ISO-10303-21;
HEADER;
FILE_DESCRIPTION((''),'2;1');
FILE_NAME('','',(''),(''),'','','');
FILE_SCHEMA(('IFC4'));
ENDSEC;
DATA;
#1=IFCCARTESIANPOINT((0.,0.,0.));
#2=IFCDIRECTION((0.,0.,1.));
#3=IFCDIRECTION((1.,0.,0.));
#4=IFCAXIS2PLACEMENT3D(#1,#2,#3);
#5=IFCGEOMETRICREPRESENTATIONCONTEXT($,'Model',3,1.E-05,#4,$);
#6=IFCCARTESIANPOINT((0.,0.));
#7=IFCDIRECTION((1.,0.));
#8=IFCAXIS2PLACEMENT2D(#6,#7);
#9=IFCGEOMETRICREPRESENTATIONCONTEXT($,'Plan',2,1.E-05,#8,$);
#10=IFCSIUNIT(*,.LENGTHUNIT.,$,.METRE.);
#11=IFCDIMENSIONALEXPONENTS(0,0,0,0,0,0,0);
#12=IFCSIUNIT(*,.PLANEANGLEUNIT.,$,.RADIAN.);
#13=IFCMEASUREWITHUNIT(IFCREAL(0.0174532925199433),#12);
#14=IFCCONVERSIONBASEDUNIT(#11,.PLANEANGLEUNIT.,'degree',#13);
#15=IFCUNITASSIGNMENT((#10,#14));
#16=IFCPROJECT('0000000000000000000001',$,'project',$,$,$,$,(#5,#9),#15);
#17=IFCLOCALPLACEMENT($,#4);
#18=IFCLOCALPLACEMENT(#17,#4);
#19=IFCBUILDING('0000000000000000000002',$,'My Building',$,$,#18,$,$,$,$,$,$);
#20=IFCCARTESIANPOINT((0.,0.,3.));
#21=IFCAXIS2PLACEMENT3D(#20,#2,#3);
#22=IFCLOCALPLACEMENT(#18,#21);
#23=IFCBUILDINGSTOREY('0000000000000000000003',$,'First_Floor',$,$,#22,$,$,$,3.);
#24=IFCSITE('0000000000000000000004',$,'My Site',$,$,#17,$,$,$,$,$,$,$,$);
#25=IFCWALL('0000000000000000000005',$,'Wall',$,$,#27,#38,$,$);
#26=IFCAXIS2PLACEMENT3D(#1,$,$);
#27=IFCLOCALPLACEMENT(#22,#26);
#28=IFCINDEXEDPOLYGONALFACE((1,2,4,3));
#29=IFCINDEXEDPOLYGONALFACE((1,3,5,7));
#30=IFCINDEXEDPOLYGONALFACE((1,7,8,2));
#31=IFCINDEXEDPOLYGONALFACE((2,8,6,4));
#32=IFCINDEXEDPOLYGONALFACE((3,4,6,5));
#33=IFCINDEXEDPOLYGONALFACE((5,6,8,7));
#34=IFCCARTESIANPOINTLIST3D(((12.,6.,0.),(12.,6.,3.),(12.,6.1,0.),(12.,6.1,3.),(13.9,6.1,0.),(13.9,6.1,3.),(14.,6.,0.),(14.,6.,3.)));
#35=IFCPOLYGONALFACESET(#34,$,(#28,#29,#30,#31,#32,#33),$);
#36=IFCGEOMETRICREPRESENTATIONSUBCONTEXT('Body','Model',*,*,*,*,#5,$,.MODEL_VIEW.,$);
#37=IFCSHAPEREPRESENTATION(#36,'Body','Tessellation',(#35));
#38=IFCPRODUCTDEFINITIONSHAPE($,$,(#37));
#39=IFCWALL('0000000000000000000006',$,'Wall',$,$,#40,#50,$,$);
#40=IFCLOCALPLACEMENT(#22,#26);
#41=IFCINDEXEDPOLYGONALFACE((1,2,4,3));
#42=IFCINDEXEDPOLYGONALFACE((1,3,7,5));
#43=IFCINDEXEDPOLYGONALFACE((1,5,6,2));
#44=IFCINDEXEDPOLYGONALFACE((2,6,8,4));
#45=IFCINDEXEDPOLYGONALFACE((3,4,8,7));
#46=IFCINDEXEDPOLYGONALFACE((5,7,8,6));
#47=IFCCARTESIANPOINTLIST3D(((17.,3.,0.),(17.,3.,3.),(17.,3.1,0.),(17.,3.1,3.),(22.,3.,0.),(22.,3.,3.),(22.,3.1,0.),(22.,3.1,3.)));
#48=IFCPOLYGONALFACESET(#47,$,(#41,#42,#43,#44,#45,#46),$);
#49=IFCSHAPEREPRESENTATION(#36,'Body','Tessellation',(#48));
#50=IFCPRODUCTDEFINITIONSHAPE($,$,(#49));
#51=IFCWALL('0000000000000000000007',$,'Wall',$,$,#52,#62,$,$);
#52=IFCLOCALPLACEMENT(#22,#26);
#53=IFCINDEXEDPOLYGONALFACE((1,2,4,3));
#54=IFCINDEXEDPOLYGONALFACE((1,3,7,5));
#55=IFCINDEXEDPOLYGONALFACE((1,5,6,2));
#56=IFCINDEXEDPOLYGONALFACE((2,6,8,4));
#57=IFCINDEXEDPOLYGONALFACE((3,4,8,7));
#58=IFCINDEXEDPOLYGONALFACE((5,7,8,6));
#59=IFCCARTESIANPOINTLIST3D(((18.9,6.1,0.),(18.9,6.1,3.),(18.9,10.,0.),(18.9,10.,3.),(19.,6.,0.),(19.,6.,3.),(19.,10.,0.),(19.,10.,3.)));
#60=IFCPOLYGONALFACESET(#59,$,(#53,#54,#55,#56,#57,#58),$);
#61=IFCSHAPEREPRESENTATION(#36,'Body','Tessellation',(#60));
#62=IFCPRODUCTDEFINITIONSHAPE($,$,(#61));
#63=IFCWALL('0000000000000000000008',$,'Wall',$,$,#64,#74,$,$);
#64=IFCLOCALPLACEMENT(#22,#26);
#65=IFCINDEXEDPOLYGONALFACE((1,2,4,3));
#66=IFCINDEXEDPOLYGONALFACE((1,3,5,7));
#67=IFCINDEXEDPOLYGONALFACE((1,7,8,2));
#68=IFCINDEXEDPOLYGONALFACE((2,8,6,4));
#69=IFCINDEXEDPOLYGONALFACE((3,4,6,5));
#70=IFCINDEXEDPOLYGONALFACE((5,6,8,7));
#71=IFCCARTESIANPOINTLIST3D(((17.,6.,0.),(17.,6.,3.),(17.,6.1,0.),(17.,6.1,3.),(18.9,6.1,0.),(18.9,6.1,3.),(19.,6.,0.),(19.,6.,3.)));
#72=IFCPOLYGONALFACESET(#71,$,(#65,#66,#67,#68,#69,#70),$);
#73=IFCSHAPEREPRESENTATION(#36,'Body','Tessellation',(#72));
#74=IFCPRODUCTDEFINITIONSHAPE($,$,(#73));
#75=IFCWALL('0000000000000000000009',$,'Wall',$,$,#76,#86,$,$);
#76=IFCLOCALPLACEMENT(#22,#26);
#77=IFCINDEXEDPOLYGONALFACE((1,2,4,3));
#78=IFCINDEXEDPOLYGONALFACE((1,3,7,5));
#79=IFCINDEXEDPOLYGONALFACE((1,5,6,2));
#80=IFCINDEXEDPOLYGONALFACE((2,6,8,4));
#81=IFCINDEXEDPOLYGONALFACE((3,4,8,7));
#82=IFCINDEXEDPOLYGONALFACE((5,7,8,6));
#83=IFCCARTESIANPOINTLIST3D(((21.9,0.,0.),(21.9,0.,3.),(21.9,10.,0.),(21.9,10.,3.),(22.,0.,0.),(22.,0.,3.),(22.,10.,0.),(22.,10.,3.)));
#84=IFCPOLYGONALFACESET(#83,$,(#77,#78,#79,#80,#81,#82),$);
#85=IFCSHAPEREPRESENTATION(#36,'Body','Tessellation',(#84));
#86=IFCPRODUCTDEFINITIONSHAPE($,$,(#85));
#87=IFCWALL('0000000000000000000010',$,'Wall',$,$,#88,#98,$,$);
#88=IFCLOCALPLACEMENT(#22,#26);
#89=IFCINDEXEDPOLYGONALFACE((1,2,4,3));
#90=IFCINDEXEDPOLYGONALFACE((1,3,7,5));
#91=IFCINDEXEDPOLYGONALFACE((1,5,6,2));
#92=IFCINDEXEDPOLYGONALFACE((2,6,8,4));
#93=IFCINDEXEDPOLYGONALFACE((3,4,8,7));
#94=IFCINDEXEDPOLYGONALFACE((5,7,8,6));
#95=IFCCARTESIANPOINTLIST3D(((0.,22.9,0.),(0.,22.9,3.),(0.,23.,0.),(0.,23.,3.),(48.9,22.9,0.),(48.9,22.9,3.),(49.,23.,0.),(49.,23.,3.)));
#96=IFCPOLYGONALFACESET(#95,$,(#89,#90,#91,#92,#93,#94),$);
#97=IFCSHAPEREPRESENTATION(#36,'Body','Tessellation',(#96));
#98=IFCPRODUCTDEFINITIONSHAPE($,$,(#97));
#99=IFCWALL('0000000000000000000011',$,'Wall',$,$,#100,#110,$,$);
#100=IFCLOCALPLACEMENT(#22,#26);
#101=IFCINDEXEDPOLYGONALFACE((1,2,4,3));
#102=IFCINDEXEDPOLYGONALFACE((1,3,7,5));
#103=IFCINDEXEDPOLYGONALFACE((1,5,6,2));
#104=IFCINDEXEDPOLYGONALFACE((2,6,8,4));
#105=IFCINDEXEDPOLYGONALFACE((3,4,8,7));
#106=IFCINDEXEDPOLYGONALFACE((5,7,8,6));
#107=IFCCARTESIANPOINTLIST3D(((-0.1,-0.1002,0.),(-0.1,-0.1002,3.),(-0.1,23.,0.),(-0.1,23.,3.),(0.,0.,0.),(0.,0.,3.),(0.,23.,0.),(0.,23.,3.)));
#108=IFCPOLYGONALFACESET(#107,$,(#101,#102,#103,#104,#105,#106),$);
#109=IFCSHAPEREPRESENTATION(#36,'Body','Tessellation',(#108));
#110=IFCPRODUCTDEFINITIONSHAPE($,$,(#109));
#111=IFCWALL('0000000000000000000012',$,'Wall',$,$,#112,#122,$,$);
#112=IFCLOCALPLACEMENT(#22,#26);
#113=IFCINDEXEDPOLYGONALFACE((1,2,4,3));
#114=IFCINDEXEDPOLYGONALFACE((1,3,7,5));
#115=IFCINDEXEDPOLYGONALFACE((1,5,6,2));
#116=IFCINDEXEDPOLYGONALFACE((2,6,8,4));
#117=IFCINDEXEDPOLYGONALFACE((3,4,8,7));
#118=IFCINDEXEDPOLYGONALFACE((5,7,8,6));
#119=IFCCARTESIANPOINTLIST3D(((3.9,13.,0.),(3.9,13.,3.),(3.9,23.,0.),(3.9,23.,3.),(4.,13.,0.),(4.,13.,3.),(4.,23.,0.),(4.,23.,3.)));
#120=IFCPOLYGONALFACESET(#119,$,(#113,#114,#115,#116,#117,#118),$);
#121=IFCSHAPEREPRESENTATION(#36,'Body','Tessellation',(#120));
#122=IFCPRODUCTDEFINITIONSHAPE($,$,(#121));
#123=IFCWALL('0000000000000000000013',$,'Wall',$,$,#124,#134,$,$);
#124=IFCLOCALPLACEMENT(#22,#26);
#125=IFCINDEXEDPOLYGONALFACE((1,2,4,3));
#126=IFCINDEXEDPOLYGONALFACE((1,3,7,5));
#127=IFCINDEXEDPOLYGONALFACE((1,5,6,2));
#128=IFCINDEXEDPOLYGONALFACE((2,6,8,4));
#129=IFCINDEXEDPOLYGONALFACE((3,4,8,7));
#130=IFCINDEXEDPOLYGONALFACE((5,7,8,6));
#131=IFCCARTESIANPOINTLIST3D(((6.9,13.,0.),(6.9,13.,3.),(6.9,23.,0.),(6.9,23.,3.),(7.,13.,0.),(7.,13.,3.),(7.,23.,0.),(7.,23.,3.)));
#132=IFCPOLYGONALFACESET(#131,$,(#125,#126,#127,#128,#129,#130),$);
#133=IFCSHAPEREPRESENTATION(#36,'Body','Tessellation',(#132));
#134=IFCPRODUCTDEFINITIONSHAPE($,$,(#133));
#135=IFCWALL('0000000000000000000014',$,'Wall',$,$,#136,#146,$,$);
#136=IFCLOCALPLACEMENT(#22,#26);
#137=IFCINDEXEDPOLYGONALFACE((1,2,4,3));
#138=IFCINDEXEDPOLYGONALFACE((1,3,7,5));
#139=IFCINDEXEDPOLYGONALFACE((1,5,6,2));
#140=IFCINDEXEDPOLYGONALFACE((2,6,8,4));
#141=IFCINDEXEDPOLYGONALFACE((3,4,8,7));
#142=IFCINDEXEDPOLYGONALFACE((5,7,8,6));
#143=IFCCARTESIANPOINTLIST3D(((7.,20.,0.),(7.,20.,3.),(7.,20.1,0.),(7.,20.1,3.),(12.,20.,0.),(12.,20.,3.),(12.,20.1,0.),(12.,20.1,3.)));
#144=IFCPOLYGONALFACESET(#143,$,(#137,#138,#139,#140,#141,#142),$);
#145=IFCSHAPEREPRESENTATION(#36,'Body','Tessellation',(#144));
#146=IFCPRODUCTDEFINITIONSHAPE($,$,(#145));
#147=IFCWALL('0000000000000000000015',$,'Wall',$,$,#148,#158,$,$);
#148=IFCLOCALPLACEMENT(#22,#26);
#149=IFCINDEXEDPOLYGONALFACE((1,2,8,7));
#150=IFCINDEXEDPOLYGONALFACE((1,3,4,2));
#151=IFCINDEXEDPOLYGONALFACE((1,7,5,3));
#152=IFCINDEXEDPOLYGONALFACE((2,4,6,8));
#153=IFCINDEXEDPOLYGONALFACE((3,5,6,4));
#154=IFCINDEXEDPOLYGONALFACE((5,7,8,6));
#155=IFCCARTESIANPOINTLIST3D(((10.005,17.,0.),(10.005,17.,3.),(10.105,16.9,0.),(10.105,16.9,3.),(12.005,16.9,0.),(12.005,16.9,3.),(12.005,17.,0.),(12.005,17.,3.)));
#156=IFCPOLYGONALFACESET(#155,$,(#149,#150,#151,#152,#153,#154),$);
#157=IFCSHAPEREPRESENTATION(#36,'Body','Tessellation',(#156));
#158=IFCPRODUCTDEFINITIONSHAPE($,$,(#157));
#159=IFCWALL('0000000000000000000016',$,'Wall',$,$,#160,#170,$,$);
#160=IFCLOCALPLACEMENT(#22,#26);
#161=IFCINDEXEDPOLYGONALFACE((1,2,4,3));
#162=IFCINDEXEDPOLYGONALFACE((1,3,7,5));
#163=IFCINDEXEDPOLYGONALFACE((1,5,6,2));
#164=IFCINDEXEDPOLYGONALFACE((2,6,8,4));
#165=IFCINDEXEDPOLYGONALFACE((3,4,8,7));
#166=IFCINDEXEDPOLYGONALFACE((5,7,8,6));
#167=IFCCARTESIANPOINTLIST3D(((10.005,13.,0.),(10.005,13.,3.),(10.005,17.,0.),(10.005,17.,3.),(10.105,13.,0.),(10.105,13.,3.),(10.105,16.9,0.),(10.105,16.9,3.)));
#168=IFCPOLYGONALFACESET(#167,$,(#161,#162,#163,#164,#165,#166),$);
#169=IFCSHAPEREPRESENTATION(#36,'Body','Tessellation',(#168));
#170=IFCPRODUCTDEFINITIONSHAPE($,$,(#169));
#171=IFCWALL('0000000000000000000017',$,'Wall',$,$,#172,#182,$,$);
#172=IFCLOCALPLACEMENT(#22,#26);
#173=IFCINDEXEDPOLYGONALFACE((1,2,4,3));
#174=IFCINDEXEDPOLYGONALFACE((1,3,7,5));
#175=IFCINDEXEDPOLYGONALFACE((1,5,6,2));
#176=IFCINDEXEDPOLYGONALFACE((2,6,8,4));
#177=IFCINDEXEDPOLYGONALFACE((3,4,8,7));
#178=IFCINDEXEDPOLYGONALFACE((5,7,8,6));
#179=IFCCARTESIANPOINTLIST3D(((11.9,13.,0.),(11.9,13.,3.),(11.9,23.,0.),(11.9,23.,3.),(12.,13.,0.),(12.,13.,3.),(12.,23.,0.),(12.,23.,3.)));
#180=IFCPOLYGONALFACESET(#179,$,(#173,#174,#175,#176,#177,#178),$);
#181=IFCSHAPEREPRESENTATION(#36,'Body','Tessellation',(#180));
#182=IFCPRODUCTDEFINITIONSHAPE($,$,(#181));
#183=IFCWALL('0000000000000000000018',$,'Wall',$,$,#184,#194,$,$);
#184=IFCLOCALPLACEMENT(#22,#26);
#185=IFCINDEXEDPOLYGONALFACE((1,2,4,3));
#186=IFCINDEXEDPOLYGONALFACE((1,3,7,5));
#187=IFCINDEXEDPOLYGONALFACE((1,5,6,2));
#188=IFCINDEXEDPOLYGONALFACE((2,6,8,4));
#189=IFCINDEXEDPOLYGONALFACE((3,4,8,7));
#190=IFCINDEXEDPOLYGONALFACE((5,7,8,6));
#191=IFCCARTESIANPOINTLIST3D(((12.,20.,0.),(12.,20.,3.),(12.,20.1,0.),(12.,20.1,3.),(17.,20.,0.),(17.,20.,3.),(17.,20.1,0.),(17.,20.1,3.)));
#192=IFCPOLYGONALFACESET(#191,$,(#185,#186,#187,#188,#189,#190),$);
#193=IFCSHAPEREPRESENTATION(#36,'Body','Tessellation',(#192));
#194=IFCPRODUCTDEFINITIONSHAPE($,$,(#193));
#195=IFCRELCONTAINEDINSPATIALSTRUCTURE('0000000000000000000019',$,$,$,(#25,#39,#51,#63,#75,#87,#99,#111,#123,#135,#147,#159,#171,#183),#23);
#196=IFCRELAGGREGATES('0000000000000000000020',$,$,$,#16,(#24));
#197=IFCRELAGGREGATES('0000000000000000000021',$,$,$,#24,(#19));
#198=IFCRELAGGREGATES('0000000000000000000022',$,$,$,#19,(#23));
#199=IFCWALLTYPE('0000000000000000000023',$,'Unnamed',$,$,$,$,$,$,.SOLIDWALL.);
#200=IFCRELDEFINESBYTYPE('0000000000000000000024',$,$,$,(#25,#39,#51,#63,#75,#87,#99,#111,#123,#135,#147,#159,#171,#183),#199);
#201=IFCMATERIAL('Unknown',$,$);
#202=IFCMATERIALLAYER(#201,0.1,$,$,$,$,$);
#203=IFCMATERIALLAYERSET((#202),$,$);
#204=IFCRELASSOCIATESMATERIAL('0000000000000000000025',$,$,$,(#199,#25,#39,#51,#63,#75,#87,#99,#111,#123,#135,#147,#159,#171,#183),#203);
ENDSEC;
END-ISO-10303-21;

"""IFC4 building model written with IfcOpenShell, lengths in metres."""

from ifc_helpers import new_model, entity, si_unit, converted_unit, frame, origin_with_axes, origin_2d_with_axis, place, context, subcontext, project, spatial, line, indexed_curve, outline, extrude, material, layer, layer_set, layer_usage, type_object, element, save


model = new_model("IFC4")

# Units and contexts
model_context = context("Model", 3, precision=1e-05, world=origin_with_axes())
plan_context = context("Plan", 2, precision=1e-05, world=origin_2d_with_axis())
body_context = subcontext(model_context, "Body", "Model", "MODEL_VIEW")
ifc_project = project(units=[si_unit("LENGTHUNIT", "METRE"), converted_unit("PLANEANGLEUNIT", "degree", entity("IfcReal", 0.0174532925199433), si_unit("PLANEANGLEUNIT", "RADIAN"), dimensions=[0, 0, 0, 0, 0, 0, 0])], contexts=[model_context, plan_context])

# Site, building, storey
site_placement = place(None, origin_with_axes())
site = spatial("IfcSite", under=ifc_project, at=site_placement, Name="My Site")
building_placement = place(site_placement, origin_with_axes())
building = spatial("IfcBuilding", under=site, at=building_placement, Name="My Building")
storey_placement = place(building_placement, frame((0.0, 0.0, 3.0), z_axis=(0.0, 0.0, 1.0), x_axis=(1.0, 0.0, 0.0)))
storey = spatial("IfcBuildingStorey", under=building, at=storey_placement, Name="First_Floor", Elevation=3.0)

# Shared definitions
ifc_material = material(Name="Unknown")

# Walls
ifc_layer = layer(ifc_material, 0.1)
ifc_layer_set = layer_set([ifc_layer])
wall_type = type_object("IfcWallType", Name="Unnamed", PredefinedType="SOLIDWALL", material=ifc_layer_set)
ifc_layer_usage_1 = layer_usage(ifc_layer_set, "AXIS2", "POSITIVE", 0.0)
wall_1_placement = place(storey_placement, frame((12.0, 6.0, 0.0), z_axis=(0.0, 0.0, 1.0), x_axis=(1.0, 0.0, 0.0)))
element("IfcWall", 1, at=wall_1_placement, inside=storey, type_object=wall_type, material=ifc_layer_usage_1, Name="Wall", context=body_context, shape_type="SweptSolid", body=[
    extrude(outline(indexed_curve([(0.0, 0.0), (0.0, 0.1), (1.9, 0.1), (2.0, 0.0)], segments=[line(1, 2, 3, 4, 1)])), origin_with_axes(), (0.0, 0.0, 1.0), 3.0),
])
ifc_layer_usage_2 = layer_usage(ifc_layer_set, "AXIS2", "POSITIVE", 0.0)
wall_2_placement = place(storey_placement, frame((17.0, 3.0, 0.0), z_axis=(0.0, 0.0, 1.0), x_axis=(1.0, 0.0, 0.0)))
element("IfcWall", 2, at=wall_2_placement, inside=storey, type_object=wall_type, material=ifc_layer_usage_2, Name="Wall", context=body_context, shape_type="SweptSolid", body=[
    extrude(outline(indexed_curve([(0.0, 0.0), (0.0, 0.1), (5.0, 0.1), (5.0, 0.0)], segments=[line(1, 2, 3, 4, 1)])), origin_with_axes(), (0.0, 0.0, 1.0), 3.0),
])
ifc_layer_usage_3 = layer_usage(ifc_layer_set, "AXIS2", "POSITIVE", 0.0)
wall_3_placement = place(storey_placement, frame((19.0, 6.0, 0.0), z_axis=(0.0, 0.0, 1.0), x_axis=(0.0, 1.0, 0.0)))
element("IfcWall", 3, at=wall_3_placement, inside=storey, type_object=wall_type, material=ifc_layer_usage_3, Name="Wall", context=body_context, shape_type="SweptSolid", body=[
    extrude(outline(indexed_curve([(0.0, 0.0), (0.1, 0.1), (4.0, 0.1), (4.0, 0.0)], segments=[line(1, 2, 3, 4, 1)])), origin_with_axes(), (0.0, 0.0, 1.0), 3.0),
])
ifc_layer_usage_4 = layer_usage(ifc_layer_set, "AXIS2", "POSITIVE", 0.0)
wall_4_placement = place(storey_placement, frame((17.0, 6.0, 0.0), z_axis=(0.0, 0.0, 1.0), x_axis=(1.0, 0.0, 0.0)))
element("IfcWall", 4, at=wall_4_placement, inside=storey, type_object=wall_type, material=ifc_layer_usage_4, Name="Wall", context=body_context, shape_type="SweptSolid", body=[
    extrude(outline(indexed_curve([(0.0, 0.0), (0.0, 0.1), (1.9, 0.1), (2.0, 0.0)], segments=[line(1, 2, 3, 4, 1)])), origin_with_axes(), (0.0, 0.0, 1.0), 3.0),
])
ifc_layer_usage_5 = layer_usage(ifc_layer_set, "AXIS2", "POSITIVE", 0.0)
wall_5_placement = place(storey_placement, frame((21.9, 10.0, 0.0), z_axis=(0.0, 0.0, 1.0), x_axis=(0.0, -1.0, 0.0)))
element("IfcWall", 5, at=wall_5_placement, inside=storey, type_object=wall_type, material=ifc_layer_usage_5, Name="Wall", context=body_context, shape_type="SweptSolid", body=[
    extrude(outline(indexed_curve([(0.0, 0.0), (0.0, 0.1), (10.0, 0.1), (10.0, 0.0)], segments=[line(1, 2, 3, 4, 1)])), origin_with_axes(), (0.0, 0.0, 1.0), 3.0),
])
ifc_layer_usage_6 = layer_usage(ifc_layer_set, "AXIS2", "POSITIVE", 0.0)
wall_6_placement = place(storey_placement, frame((0.0, 22.9, 0.0), z_axis=(0.0, 0.0, 1.0), x_axis=(1.0, 0.0, 0.0)))
element("IfcWall", 6, at=wall_6_placement, inside=storey, type_object=wall_type, material=ifc_layer_usage_6, Name="Wall", context=body_context, shape_type="SweptSolid", body=[
    extrude(outline(indexed_curve([(0.0, 0.0), (0.0, 0.1), (49.0, 0.1), (48.9, 0.0)], segments=[line(1, 2, 3, 4, 1)])), origin_with_axes(), (0.0, 0.0, 1.0), 3.0),
])
ifc_layer_usage_7 = layer_usage(ifc_layer_set, "AXIS2", "POSITIVE", 0.0)
wall_7_placement = place(storey_placement, frame((0.0, 0.0, 0.0), z_axis=(0.0, 0.0, 1.0), x_axis=(0.0, 1.0, 0.0)))
element("IfcWall", 7, at=wall_7_placement, inside=storey, type_object=wall_type, material=ifc_layer_usage_7, Name="Wall", context=body_context, shape_type="SweptSolid", body=[
    extrude(outline(indexed_curve([(0.0, 0.0), (-0.1002, 0.1), (23.0, 0.1), (23.0, 0.0)], segments=[line(1, 2, 3, 4, 1)])), origin_with_axes(), (0.0, 0.0, 1.0), 3.0),
])
ifc_layer_usage_8 = layer_usage(ifc_layer_set, "AXIS2", "POSITIVE", 0.0)
wall_8_placement = place(storey_placement, frame((3.9, 23.0, 0.0), z_axis=(0.0, 0.0, 1.0), x_axis=(0.0, -1.0, 0.0)))
element("IfcWall", 8, at=wall_8_placement, inside=storey, type_object=wall_type, material=ifc_layer_usage_8, Name="Wall", context=body_context, shape_type="SweptSolid", body=[
    extrude(outline(indexed_curve([(0.0, 0.0), (0.0, 0.1), (10.0, 0.1), (10.0, 0.0)], segments=[line(1, 2, 3, 4, 1)])), origin_with_axes(), (0.0, 0.0, 1.0), 3.0),
])
ifc_layer_usage_9 = layer_usage(ifc_layer_set, "AXIS2", "POSITIVE", 0.0)
wall_9_placement = place(storey_placement, frame((6.9, 23.0, 0.0), z_axis=(0.0, 0.0, 1.0), x_axis=(0.0, -1.0, 0.0)))
element("IfcWall", 9, at=wall_9_placement, inside=storey, type_object=wall_type, material=ifc_layer_usage_9, Name="Wall", context=body_context, shape_type="SweptSolid", body=[
    extrude(outline(indexed_curve([(0.0, 0.0), (0.0, 0.1), (10.0, 0.1), (10.0, 0.0)], segments=[line(1, 2, 3, 4, 1)])), origin_with_axes(), (0.0, 0.0, 1.0), 3.0),
])
ifc_layer_usage_10 = layer_usage(ifc_layer_set, "AXIS2", "POSITIVE", 0.0)
wall_10_placement = place(storey_placement, frame((7.0, 20.0, 0.0), z_axis=(0.0, 0.0, 1.0), x_axis=(1.0, 0.0, 0.0)))
element("IfcWall", 10, at=wall_10_placement, inside=storey, type_object=wall_type, material=ifc_layer_usage_10, Name="Wall", context=body_context, shape_type="SweptSolid", body=[
    extrude(outline(indexed_curve([(0.0, 0.0), (0.0, 0.1), (5.0, 0.1), (5.0, 0.0)], segments=[line(1, 2, 3, 4, 1)])), origin_with_axes(), (0.0, 0.0, 1.0), 3.0),
])
ifc_layer_usage_11 = layer_usage(ifc_layer_set, "AXIS2", "POSITIVE", 0.0)
wall_11_placement = place(storey_placement, frame((12.005, 17.0, 0.0), z_axis=(0.0, 0.0, 1.0), x_axis=(-1.0, 0.0, 0.0)))
element("IfcWall", 11, at=wall_11_placement, inside=storey, type_object=wall_type, material=ifc_layer_usage_11, Name="Wall", context=body_context, shape_type="SweptSolid", body=[
    extrude(outline(indexed_curve([(0.0, 0.0), (0.0, 0.1), (1.9, 0.1), (2.0, 0.0)], segments=[line(1, 2, 3, 4, 1)])), origin_with_axes(), (0.0, 0.0, 1.0), 3.0),
])
ifc_layer_usage_12 = layer_usage(ifc_layer_set, "AXIS2", "POSITIVE", 0.0)
wall_12_placement = place(storey_placement, frame((10.005, 17.0, 0.0), z_axis=(0.0, 0.0, 1.0), x_axis=(0.0, -1.0, 0.0)))
element("IfcWall", 12, at=wall_12_placement, inside=storey, type_object=wall_type, material=ifc_layer_usage_12, Name="Wall", context=body_context, shape_type="SweptSolid", body=[
    extrude(outline(indexed_curve([(0.0, 0.0), (0.1, 0.1), (4.0, 0.1), (4.0, 0.0)], segments=[line(1, 2, 3, 4, 1)])), origin_with_axes(), (0.0, 0.0, 1.0), 3.0),
])
ifc_layer_usage_13 = layer_usage(ifc_layer_set, "AXIS2", "POSITIVE", 0.0)
wall_13_placement = place(storey_placement, frame((11.9, 23.0, 0.0), z_axis=(0.0, 0.0, 1.0), x_axis=(0.0, -1.0, 0.0)))
element("IfcWall", 13, at=wall_13_placement, inside=storey, type_object=wall_type, material=ifc_layer_usage_13, Name="Wall", context=body_context, shape_type="SweptSolid", body=[
    extrude(outline(indexed_curve([(0.0, 0.0), (0.0, 0.1), (10.0, 0.1), (10.0, 0.0)], segments=[line(1, 2, 3, 4, 1)])), origin_with_axes(), (0.0, 0.0, 1.0), 3.0),
])
ifc_layer_usage_14 = layer_usage(ifc_layer_set, "AXIS2", "POSITIVE", 0.0)
wall_14_placement = place(storey_placement, frame((12.0, 20.0, 0.0), z_axis=(0.0, 0.0, 1.0), x_axis=(1.0, 0.0, 0.0)))
element("IfcWall", 14, at=wall_14_placement, inside=storey, type_object=wall_type, material=ifc_layer_usage_14, Name="Wall", context=body_context, shape_type="SweptSolid", body=[
    extrude(outline(indexed_curve([(0.0, 0.0), (0.0, 0.1), (5.0, 0.1), (5.0, 0.0)], segments=[line(1, 2, 3, 4, 1)])), origin_with_axes(), (0.0, 0.0, 1.0), 3.0),
])

save(model, "model.ifc")
